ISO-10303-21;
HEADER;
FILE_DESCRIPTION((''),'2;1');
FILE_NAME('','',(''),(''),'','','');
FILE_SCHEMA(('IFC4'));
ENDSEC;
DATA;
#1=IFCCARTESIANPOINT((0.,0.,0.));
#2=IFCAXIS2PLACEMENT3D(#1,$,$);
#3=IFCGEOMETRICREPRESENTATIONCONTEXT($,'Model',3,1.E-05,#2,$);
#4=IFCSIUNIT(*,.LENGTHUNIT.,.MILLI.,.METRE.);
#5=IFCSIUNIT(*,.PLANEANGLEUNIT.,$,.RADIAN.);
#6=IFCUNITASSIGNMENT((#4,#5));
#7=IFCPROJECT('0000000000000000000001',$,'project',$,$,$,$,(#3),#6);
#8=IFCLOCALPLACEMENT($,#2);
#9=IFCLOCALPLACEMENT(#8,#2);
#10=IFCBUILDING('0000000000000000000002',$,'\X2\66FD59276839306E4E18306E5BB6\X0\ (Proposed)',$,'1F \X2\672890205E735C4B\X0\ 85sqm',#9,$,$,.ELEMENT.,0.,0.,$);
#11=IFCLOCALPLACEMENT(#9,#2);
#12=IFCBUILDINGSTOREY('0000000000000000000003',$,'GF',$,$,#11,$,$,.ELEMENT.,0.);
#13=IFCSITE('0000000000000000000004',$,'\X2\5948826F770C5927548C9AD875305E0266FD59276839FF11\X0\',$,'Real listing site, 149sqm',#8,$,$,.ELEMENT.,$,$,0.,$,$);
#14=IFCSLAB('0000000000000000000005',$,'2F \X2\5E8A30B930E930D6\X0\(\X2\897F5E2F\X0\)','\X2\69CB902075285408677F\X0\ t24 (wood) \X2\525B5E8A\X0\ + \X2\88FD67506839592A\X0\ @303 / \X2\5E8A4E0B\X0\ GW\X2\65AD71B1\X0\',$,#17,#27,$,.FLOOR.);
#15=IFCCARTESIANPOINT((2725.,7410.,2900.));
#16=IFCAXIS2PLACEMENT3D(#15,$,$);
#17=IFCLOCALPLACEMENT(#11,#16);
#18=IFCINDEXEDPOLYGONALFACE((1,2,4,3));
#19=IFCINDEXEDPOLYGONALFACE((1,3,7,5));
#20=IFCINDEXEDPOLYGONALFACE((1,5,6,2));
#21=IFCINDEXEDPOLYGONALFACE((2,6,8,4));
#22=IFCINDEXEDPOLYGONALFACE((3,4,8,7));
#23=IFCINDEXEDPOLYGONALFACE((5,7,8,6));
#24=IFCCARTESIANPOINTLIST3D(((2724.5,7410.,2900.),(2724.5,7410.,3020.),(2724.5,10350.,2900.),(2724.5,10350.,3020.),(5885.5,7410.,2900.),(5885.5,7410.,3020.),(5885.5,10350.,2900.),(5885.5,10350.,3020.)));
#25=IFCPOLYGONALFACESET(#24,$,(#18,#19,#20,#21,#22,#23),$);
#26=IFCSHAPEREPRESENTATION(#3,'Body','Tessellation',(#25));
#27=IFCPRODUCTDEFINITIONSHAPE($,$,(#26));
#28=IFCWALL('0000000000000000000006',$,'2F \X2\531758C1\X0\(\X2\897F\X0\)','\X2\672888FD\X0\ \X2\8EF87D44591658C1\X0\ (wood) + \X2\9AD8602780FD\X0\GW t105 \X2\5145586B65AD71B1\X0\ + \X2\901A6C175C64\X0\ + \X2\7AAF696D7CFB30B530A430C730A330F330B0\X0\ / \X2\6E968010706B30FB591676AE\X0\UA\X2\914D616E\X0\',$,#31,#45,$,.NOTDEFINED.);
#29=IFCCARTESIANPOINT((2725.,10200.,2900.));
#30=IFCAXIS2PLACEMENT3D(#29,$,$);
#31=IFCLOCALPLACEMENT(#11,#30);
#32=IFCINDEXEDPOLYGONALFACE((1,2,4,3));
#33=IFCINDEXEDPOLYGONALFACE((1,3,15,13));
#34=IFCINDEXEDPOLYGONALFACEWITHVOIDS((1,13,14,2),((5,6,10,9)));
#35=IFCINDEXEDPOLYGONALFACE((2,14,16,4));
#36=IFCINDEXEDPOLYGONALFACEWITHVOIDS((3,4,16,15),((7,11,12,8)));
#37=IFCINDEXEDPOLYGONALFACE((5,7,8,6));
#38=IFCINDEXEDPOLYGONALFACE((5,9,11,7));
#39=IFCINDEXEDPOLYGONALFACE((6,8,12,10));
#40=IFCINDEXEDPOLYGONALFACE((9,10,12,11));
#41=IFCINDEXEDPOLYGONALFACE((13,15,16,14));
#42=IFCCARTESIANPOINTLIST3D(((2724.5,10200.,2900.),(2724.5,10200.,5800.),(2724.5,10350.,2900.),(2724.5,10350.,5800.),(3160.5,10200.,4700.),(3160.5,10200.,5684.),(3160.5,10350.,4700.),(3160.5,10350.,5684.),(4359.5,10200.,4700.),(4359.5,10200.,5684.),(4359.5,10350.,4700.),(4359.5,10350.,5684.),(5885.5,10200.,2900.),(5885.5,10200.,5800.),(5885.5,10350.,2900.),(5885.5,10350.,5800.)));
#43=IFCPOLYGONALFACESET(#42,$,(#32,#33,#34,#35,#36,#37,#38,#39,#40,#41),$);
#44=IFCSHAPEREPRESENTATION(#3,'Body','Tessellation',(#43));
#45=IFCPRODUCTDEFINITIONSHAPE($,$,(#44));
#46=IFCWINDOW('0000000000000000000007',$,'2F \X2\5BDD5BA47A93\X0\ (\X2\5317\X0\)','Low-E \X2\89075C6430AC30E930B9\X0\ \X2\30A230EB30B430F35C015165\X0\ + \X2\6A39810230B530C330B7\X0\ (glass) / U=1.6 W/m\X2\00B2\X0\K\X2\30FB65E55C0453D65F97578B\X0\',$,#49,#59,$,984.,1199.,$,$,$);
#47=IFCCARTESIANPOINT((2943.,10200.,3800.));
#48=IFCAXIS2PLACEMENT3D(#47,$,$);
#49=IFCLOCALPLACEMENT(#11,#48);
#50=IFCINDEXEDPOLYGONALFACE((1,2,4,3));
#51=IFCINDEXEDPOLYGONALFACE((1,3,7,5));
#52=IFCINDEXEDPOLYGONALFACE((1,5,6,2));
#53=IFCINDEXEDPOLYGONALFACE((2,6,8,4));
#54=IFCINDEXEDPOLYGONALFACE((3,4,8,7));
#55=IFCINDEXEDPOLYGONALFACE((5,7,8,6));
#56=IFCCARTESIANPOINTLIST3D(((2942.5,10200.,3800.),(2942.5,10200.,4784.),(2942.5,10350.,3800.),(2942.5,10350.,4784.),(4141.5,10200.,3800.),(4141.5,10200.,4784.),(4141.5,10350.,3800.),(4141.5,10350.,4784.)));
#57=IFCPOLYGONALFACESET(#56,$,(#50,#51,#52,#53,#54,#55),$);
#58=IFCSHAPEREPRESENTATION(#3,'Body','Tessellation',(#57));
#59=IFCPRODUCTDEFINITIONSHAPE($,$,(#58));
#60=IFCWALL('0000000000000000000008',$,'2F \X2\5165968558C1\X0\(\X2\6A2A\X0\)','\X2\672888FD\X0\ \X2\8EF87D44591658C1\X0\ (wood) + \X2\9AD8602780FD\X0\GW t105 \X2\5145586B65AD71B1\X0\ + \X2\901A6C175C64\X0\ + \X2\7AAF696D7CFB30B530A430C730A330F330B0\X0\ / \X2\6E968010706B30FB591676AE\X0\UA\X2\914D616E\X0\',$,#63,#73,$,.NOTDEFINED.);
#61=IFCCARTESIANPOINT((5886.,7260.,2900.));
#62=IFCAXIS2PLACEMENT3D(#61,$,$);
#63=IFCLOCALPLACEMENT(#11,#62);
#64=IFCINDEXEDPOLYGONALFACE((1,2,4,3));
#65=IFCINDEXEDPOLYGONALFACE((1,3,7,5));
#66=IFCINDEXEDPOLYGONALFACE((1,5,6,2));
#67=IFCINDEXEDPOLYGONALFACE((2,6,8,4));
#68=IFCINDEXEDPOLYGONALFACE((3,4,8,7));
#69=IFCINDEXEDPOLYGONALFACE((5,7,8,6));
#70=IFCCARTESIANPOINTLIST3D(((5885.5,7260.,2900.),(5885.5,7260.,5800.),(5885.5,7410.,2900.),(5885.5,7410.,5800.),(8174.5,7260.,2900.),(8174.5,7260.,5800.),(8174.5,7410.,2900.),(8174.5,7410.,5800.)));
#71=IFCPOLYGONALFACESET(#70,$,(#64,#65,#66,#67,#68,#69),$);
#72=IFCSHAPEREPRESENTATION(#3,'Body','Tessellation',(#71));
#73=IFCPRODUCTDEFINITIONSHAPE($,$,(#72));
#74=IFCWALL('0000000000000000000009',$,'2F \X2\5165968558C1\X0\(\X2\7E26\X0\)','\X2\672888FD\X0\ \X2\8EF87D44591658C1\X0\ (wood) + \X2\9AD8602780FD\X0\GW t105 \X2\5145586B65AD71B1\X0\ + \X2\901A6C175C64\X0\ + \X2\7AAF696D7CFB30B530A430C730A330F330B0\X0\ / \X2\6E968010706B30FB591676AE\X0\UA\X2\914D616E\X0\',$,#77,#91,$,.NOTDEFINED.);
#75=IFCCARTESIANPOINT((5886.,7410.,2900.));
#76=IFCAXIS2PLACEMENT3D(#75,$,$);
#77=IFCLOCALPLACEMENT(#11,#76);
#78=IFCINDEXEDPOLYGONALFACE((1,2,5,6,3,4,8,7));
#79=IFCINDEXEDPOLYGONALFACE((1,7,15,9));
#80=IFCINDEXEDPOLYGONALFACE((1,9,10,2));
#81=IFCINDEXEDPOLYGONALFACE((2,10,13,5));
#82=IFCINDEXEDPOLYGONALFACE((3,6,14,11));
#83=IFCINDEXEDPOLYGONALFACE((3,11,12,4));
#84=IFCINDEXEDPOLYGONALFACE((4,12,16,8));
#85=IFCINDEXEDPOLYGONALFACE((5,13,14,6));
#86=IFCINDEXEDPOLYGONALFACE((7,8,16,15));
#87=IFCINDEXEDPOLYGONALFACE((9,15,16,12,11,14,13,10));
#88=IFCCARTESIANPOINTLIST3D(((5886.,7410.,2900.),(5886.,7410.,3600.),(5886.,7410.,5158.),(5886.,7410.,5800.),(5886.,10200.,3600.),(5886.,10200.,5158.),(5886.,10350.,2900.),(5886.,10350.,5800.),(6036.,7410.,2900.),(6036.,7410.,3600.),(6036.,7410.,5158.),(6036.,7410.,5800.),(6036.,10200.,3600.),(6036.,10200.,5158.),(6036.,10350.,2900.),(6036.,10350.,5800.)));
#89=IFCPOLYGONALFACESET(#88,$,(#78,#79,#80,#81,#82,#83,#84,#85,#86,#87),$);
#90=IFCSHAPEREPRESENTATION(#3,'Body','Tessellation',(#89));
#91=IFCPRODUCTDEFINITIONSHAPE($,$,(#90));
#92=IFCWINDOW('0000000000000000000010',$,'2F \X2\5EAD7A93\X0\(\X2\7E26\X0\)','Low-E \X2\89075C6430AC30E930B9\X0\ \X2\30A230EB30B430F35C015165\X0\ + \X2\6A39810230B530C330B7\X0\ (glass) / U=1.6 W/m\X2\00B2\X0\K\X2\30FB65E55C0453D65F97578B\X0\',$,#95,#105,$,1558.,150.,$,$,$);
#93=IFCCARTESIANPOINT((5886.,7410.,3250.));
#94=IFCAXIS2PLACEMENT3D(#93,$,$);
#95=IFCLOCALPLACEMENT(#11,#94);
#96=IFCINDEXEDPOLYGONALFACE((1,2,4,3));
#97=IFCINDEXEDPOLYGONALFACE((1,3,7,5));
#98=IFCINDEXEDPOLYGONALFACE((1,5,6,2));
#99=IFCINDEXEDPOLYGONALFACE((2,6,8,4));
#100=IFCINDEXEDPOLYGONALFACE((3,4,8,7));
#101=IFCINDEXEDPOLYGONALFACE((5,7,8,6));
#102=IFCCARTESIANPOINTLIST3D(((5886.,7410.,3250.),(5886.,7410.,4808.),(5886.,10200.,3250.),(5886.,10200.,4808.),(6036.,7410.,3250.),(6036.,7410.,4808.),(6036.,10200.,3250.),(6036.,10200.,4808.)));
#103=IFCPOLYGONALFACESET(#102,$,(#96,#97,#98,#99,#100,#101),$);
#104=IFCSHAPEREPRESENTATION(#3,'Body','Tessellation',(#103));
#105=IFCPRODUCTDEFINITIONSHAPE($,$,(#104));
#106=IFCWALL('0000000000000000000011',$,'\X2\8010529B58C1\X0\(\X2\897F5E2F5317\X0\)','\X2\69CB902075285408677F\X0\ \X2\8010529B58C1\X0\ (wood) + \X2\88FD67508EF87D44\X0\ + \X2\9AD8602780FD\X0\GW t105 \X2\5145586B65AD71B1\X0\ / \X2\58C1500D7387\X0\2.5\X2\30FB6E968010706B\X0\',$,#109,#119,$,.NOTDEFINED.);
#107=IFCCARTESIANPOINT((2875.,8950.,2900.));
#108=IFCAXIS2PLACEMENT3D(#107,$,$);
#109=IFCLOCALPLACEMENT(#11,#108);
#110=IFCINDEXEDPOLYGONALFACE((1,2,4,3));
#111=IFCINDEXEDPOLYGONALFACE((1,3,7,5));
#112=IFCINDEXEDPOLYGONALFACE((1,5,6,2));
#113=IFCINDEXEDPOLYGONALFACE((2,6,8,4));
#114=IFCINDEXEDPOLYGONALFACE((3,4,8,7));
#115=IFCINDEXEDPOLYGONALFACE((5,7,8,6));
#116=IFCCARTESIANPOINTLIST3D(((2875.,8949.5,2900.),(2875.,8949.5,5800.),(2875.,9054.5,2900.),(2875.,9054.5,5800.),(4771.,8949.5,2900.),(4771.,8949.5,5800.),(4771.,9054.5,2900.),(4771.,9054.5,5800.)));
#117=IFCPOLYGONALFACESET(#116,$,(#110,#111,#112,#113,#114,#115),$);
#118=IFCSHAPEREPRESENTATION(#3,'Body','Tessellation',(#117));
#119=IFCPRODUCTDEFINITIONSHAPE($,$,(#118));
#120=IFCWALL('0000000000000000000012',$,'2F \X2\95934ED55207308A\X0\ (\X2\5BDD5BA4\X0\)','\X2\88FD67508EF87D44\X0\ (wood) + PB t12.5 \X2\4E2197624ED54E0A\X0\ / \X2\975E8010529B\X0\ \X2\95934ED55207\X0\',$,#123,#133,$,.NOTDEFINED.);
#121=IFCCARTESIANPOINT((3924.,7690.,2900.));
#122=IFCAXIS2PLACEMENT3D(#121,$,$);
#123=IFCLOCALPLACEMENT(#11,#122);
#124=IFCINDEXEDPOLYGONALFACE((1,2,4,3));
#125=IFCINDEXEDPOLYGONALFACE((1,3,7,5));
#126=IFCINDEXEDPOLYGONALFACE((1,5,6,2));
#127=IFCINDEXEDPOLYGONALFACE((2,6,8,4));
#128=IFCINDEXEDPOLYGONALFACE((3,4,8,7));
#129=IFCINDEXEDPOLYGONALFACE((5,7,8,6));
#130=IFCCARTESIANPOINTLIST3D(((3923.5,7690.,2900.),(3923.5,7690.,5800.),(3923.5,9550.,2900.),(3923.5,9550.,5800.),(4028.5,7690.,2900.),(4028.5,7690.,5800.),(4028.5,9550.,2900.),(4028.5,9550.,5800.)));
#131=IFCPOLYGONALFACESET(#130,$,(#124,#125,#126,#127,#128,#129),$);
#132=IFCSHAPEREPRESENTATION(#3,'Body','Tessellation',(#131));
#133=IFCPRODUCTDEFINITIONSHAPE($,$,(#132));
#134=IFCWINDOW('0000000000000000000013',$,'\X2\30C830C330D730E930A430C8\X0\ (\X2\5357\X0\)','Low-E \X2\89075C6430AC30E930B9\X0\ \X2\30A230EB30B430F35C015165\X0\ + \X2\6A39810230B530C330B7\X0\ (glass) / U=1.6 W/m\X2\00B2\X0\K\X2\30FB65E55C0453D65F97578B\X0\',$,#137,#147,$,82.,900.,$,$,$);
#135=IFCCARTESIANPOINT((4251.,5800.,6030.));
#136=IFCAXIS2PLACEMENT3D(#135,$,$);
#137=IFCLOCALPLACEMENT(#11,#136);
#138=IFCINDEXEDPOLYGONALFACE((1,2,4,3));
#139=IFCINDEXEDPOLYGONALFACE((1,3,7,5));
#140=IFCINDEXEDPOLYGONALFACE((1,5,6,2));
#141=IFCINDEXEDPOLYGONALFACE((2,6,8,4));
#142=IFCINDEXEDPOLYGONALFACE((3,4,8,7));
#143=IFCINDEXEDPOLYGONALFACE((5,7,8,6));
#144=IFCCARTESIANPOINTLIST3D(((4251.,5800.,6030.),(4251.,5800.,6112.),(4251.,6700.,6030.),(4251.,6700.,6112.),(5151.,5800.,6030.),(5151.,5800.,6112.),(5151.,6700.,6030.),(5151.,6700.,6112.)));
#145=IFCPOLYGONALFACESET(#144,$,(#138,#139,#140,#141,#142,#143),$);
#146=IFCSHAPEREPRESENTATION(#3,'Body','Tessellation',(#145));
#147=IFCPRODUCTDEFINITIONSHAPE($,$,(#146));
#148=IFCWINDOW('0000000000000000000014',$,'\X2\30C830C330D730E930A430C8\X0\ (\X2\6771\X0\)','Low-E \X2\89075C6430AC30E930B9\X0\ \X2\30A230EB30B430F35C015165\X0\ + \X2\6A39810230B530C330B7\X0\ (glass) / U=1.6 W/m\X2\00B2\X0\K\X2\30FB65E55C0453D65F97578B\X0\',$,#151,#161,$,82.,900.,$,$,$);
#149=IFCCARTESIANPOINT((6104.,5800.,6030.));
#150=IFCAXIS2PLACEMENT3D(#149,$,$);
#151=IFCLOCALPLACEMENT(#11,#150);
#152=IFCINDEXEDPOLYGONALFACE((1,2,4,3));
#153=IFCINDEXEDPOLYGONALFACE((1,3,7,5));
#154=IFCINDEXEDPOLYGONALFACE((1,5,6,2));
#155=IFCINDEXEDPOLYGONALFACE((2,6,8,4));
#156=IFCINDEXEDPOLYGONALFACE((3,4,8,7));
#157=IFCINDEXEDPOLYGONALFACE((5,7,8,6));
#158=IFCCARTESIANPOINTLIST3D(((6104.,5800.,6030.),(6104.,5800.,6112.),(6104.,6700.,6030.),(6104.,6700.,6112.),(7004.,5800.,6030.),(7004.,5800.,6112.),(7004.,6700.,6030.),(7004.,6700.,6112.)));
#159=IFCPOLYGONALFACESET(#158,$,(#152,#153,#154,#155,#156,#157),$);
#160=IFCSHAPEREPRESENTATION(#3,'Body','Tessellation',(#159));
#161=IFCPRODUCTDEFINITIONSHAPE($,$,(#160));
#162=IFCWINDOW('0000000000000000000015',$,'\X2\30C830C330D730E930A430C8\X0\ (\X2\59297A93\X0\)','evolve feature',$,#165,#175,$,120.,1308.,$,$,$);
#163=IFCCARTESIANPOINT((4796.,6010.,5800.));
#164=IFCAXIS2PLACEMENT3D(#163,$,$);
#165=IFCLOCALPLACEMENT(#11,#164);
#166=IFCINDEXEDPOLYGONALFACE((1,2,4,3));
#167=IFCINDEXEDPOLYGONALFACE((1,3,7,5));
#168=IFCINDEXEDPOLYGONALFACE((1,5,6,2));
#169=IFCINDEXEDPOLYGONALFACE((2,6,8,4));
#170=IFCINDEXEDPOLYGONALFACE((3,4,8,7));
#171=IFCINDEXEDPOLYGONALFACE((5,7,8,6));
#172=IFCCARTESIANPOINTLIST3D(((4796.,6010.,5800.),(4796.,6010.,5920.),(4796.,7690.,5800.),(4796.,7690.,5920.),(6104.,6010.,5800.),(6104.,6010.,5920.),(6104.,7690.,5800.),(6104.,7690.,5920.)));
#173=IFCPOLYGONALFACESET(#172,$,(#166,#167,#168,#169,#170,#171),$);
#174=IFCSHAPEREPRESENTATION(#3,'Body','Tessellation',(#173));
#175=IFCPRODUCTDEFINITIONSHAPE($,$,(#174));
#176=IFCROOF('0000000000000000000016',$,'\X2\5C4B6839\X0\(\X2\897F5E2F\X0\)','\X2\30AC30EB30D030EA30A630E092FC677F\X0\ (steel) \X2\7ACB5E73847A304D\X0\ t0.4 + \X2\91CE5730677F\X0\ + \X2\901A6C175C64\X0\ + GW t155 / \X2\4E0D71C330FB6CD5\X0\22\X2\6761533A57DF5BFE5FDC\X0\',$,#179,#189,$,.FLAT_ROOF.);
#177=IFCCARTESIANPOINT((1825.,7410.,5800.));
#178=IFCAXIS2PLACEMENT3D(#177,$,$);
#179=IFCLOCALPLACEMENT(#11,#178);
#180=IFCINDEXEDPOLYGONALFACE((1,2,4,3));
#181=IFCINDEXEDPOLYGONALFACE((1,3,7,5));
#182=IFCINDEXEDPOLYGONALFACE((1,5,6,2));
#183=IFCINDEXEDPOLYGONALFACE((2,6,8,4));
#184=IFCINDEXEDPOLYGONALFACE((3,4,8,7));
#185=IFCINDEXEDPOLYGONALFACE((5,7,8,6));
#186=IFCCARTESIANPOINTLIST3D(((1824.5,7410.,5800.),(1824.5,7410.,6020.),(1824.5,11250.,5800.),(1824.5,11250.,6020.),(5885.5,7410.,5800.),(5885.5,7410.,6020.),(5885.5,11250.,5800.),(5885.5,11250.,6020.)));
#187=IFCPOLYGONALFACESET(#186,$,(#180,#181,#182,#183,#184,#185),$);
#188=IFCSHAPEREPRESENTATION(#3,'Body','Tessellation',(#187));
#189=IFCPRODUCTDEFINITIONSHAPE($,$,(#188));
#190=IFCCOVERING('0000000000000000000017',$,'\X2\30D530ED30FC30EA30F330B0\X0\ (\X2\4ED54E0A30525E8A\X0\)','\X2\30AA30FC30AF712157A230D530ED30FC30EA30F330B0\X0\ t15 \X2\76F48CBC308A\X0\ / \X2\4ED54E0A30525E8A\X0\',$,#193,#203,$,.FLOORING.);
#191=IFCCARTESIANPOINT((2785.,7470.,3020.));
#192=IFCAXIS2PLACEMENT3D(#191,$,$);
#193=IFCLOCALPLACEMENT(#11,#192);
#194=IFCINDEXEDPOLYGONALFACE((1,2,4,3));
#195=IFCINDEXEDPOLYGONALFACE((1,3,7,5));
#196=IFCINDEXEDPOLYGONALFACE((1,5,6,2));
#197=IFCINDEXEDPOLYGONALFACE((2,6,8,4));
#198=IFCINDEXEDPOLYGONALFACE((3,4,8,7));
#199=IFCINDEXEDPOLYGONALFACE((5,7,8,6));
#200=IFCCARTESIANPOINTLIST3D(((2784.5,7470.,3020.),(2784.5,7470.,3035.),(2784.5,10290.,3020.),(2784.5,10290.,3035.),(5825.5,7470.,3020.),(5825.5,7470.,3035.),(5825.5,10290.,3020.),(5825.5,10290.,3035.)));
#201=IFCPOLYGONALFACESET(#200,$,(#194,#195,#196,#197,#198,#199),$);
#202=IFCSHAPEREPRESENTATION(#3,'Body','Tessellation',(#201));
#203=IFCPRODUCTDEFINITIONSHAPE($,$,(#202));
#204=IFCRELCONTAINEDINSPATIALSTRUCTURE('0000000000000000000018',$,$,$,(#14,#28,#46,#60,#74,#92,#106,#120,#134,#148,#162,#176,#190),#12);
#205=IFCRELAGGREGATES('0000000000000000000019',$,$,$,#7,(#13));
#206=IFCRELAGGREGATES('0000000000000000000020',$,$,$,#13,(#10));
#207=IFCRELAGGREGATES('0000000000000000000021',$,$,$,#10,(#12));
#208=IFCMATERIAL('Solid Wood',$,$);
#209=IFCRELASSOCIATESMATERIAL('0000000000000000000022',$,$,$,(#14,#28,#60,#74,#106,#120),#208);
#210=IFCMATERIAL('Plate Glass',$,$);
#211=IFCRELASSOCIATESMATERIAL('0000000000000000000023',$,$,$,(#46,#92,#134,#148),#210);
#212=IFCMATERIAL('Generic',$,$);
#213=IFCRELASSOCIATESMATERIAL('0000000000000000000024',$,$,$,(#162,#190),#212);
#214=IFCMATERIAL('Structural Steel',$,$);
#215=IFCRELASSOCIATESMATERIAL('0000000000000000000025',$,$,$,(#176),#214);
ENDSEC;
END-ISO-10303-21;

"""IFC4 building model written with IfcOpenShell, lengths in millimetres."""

from ifc_helpers import new_model, si_unit, frame, frame_2d, origin, place, context, project, spatial, rectangle, extrude, material, element, fill, save


model = new_model("IFC4")

# Units and contexts
model_context = context("Model", 3, precision=1e-05, world=origin())
ifc_project = project(units=[si_unit("LENGTHUNIT", "METRE", prefix="MILLI"), si_unit("PLANEANGLEUNIT", "RADIAN")], contexts=[model_context])

# Site, building, storey
site_placement = place(None, origin())
site = spatial("IfcSite", under=ifc_project, at=site_placement, Name="奈良県大和高田市曽大根１", ObjectType="Real listing site, 149sqm", CompositionType="ELEMENT", RefElevation=0.0)
building_placement = place(site_placement, origin())
building = spatial("IfcBuilding", under=site, at=building_placement, Name="曽大根の丘の家 (Proposed)", ObjectType="1F 木造平屋 85sqm", CompositionType="ELEMENT", ElevationOfRefHeight=0.0, ElevationOfTerrain=0.0)
storey_placement = place(building_placement, origin())
storey = spatial("IfcBuildingStorey", under=building, at=storey_placement, Name="GF", CompositionType="ELEMENT", Elevation=0.0)

# Slab
ifc_material_1 = material(Name="Solid Wood")
slab_placement = place(storey_placement, frame((2725.0, 7410.0, 2900.0)))
element("IfcSlab", 1, at=slab_placement, inside=storey, material=ifc_material_1, Name="2F 床スラブ(西帯)", Description="構造用合板 t24 (wood) 剛床 + 製材根太 @303 / 床下 GW断熱", PredefinedType="FLOOR", context=model_context, shape_type="SweptSolid", body=[
    extrude(rectangle(XDim=3161.0, YDim=2940.0, at=frame_2d((1580.0, 1470.0))), frame((2725.0, 7410.0, 2900.0)), (0.0, 0.0, 1.0), 120.0),
])

# Wall, opening, window
wall_1_placement = place(storey_placement, frame((2725.0, 10200.0, 2900.0)))
wall_1 = element("IfcWall", 2, at=wall_1_placement, inside=storey, material=ifc_material_1, Name="2F 北壁(西)", Description="木製 軸組外壁 (wood) + 高性能GW t105 充填断熱 + 通気層 + 窯業系サイディング / 準耐火・外皮UA配慮", PredefinedType="NOTDEFINED", context=model_context, shape_type="SweptSolid", body=[
    extrude(rectangle(XDim=3161.0, YDim=150.0, at=frame_2d((1580.0, 75.0))), frame((2725.0, 10200.0, 2900.0)), (0.0, 0.0, 1.0), 2900.0),
])
opening_1_placement = place(storey_placement, frame((2943.0, 10200.0, 3800.0)))
opening_1 = element("IfcOpeningElement", 3, at=opening_1_placement, cuts=wall_1, PredefinedType="NOTDEFINED", context=model_context, shape_type="SweptSolid", body=[
    extrude(rectangle(XDim=1199.0, YDim=150.0, at=frame_2d((599.0, 75.0))), frame((2943.0, 10200.0, 3800.0)), (0.0, 0.0, 1.0), 984.0),
])
ifc_material_2 = material(Name="Plate Glass")
window_1_placement = place(storey_placement, frame((2943.0, 10200.0, 3800.0)))
window_1 = element("IfcWindow", 4, at=window_1_placement, inside=storey, material=ifc_material_2, Name="2F 寝室窓 (北)", Description="Low-E 複層ガラス アルゴン封入 + 樹脂サッシ (glass) / U=1.6 W/m²K・日射取得型", OverallHeight=984.0, OverallWidth=1199.0, context=model_context, shape_type="SweptSolid", body=[
    extrude(rectangle(XDim=1199.0, YDim=150.0, at=frame_2d((599.0, 75.0))), frame((2943.0, 10200.0, 3800.0)), (0.0, 0.0, 1.0), 984.0),
])
fill(opening_1, window_1)

# Wall
wall_2_placement = place(storey_placement, frame((5886.0, 7260.0, 2900.0)))
element("IfcWall", 5, at=wall_2_placement, inside=storey, material=ifc_material_1, Name="2F 入隅壁(横)", Description="木製 軸組外壁 (wood) + 高性能GW t105 充填断熱 + 通気層 + 窯業系サイディング / 準耐火・外皮UA配慮", PredefinedType="NOTDEFINED", context=model_context, shape_type="SweptSolid", body=[
    extrude(rectangle(XDim=2289.0, YDim=150.0, at=frame_2d((1144.0, 75.0))), frame((5886.0, 7260.0, 2900.0)), (0.0, 0.0, 1.0), 2900.0),
])

# Wall, opening, window
wall_3_placement = place(storey_placement, frame((5886.0, 7410.0, 2900.0)))
wall_3 = element("IfcWall", 6, at=wall_3_placement, inside=storey, material=ifc_material_1, Name="2F 入隅壁(縦)", Description="木製 軸組外壁 (wood) + 高性能GW t105 充填断熱 + 通気層 + 窯業系サイディング / 準耐火・外皮UA配慮", PredefinedType="NOTDEFINED", context=model_context, shape_type="SweptSolid", body=[
    extrude(rectangle(XDim=150.0, YDim=2940.0, at=frame_2d((75.0, 1470.0))), frame((5886.0, 7410.0, 2900.0)), (0.0, 0.0, 1.0), 2900.0),
])
opening_2_placement = place(storey_placement, frame((5886.0, 7410.0, 3250.0)))
opening_2 = element("IfcOpeningElement", 7, at=opening_2_placement, cuts=wall_3, PredefinedType="NOTDEFINED", context=model_context, shape_type="SweptSolid", body=[
    extrude(rectangle(XDim=150.0, YDim=2790.0, at=frame_2d((75.0, 1395.0))), frame((5886.0, 7410.0, 3250.0)), (0.0, 0.0, 1.0), 1558.0),
])
window_2_placement = place(storey_placement, frame((5886.0, 7410.0, 3250.0)))
window_2 = element("IfcWindow", 8, at=window_2_placement, inside=storey, material=ifc_material_2, Name="2F 庭窓(縦)", Description="Low-E 複層ガラス アルゴン封入 + 樹脂サッシ (glass) / U=1.6 W/m²K・日射取得型", OverallHeight=1558.0, OverallWidth=150.0, context=model_context, shape_type="SweptSolid", body=[
    extrude(rectangle(XDim=150.0, YDim=2790.0, at=frame_2d((75.0, 1395.0))), frame((5886.0, 7410.0, 3250.0)), (0.0, 0.0, 1.0), 1558.0),
])
fill(opening_2, window_2)

# Walls
wall_4_placement = place(storey_placement, frame((2875.0, 8950.0, 2900.0)))
element("IfcWall", 9, at=wall_4_placement, inside=storey, material=ifc_material_1, Name="耐力壁(西帯北)", Description="構造用合板 耐力壁 (wood) + 製材軸組 + 高性能GW t105 充填断熱 / 壁倍率2.5・準耐火", PredefinedType="NOTDEFINED", context=model_context, shape_type="SweptSolid", body=[
    extrude(rectangle(XDim=1896.0, YDim=105.0, at=frame_2d((948.0, 52.0))), frame((2875.0, 8950.0, 2900.0)), (0.0, 0.0, 1.0), 2900.0),
])
wall_5_placement = place(storey_placement, frame((3924.0, 7690.0, 2900.0)))
element("IfcWall", 10, at=wall_5_placement, inside=storey, material=ifc_material_1, Name="2F 間仕切り (寝室)", Description="製材軸組 (wood) + PB t12.5 両面仕上 / 非耐力 間仕切", PredefinedType="NOTDEFINED", context=model_context, shape_type="SweptSolid", body=[
    extrude(rectangle(XDim=105.0, YDim=1860.0, at=frame_2d((52.0, 930.0))), frame((3924.0, 7690.0, 2900.0)), (0.0, 0.0, 1.0), 2900.0),
])

# Windows
window_3_placement = place(storey_placement, frame((4251.0, 5800.0, 6030.0)))
element("IfcWindow", 11, at=window_3_placement, inside=storey, material=ifc_material_2, Name="トップライト (南)", Description="Low-E 複層ガラス アルゴン封入 + 樹脂サッシ (glass) / U=1.6 W/m²K・日射取得型", OverallHeight=82.0, OverallWidth=900.0, context=model_context, shape_type="SweptSolid", body=[
    extrude(rectangle(XDim=900.0, YDim=900.0, at=frame_2d((450.0, 450.0))), frame((4251.0, 5800.0, 6030.0)), (0.0, 0.0, 1.0), 82.0),
])
window_4_placement = place(storey_placement, frame((6104.0, 5800.0, 6030.0)))
element("IfcWindow", 12, at=window_4_placement, inside=storey, material=ifc_material_2, Name="トップライト (東)", Description="Low-E 複層ガラス アルゴン封入 + 樹脂サッシ (glass) / U=1.6 W/m²K・日射取得型", OverallHeight=82.0, OverallWidth=900.0, context=model_context, shape_type="SweptSolid", body=[
    extrude(rectangle(XDim=900.0, YDim=900.0, at=frame_2d((450.0, 450.0))), frame((6104.0, 5800.0, 6030.0)), (0.0, 0.0, 1.0), 82.0),
])
ifc_material_3 = material(Name="Generic")
window_5_placement = place(storey_placement, frame((4796.0, 6010.0, 5800.0)))
element("IfcWindow", 13, at=window_5_placement, inside=storey, material=ifc_material_3, Name="トップライト (天窓)", Description="evolve feature", OverallHeight=120.0, OverallWidth=1308.0, context=model_context, shape_type="SweptSolid", body=[
    extrude(rectangle(XDim=1308.0, YDim=1680.0, at=frame_2d((654.0, 840.0))), frame((4796.0, 6010.0, 5800.0)), (0.0, 0.0, 1.0), 120.0),
])

# Roof
ifc_material_4 = material(Name="Structural Steel")
for number, where, name in (
    (14, (1825.0, 7410.0, 5800.0), "屋根(西帯)"),
):
    element("IfcRoof", number, at=place(storey_placement, frame(where)), inside=storey, material=ifc_material_4, Name=name, Description="ガルバリウム鋼板 (steel) 立平葺き t0.4 + 野地板 + 通気層 + GW t155 / 不燃・法22条区域対応", PredefinedType="FLAT_ROOF", context=model_context, shape_type="SweptSolid", body=[
        extrude(rectangle(XDim=4061.0, YDim=3840.0, at=frame_2d((2030.0, 1920.0))), frame((1825.0, 7410.0, 5800.0)), (0.0, 0.0, 1.0), 220.0),
    ])

# Covering
covering_placement = place(storey_placement, frame((2785.0, 7470.0, 3020.0)))
element("IfcCovering", 15, at=covering_placement, inside=storey, material=ifc_material_3, Name="フローリング (仕上げ床)", Description="オーク無垢フローリング t15 直貼り / 仕上げ床", PredefinedType="FLOORING", context=model_context, shape_type="SweptSolid", body=[
    extrude(rectangle(XDim=3041.0, YDim=2820.0, at=frame_2d((1520.0, 1410.0))), frame((2785.0, 7470.0, 3020.0)), (0.0, 0.0, 1.0), 15.0),
])

save(model, "model.ifc")
